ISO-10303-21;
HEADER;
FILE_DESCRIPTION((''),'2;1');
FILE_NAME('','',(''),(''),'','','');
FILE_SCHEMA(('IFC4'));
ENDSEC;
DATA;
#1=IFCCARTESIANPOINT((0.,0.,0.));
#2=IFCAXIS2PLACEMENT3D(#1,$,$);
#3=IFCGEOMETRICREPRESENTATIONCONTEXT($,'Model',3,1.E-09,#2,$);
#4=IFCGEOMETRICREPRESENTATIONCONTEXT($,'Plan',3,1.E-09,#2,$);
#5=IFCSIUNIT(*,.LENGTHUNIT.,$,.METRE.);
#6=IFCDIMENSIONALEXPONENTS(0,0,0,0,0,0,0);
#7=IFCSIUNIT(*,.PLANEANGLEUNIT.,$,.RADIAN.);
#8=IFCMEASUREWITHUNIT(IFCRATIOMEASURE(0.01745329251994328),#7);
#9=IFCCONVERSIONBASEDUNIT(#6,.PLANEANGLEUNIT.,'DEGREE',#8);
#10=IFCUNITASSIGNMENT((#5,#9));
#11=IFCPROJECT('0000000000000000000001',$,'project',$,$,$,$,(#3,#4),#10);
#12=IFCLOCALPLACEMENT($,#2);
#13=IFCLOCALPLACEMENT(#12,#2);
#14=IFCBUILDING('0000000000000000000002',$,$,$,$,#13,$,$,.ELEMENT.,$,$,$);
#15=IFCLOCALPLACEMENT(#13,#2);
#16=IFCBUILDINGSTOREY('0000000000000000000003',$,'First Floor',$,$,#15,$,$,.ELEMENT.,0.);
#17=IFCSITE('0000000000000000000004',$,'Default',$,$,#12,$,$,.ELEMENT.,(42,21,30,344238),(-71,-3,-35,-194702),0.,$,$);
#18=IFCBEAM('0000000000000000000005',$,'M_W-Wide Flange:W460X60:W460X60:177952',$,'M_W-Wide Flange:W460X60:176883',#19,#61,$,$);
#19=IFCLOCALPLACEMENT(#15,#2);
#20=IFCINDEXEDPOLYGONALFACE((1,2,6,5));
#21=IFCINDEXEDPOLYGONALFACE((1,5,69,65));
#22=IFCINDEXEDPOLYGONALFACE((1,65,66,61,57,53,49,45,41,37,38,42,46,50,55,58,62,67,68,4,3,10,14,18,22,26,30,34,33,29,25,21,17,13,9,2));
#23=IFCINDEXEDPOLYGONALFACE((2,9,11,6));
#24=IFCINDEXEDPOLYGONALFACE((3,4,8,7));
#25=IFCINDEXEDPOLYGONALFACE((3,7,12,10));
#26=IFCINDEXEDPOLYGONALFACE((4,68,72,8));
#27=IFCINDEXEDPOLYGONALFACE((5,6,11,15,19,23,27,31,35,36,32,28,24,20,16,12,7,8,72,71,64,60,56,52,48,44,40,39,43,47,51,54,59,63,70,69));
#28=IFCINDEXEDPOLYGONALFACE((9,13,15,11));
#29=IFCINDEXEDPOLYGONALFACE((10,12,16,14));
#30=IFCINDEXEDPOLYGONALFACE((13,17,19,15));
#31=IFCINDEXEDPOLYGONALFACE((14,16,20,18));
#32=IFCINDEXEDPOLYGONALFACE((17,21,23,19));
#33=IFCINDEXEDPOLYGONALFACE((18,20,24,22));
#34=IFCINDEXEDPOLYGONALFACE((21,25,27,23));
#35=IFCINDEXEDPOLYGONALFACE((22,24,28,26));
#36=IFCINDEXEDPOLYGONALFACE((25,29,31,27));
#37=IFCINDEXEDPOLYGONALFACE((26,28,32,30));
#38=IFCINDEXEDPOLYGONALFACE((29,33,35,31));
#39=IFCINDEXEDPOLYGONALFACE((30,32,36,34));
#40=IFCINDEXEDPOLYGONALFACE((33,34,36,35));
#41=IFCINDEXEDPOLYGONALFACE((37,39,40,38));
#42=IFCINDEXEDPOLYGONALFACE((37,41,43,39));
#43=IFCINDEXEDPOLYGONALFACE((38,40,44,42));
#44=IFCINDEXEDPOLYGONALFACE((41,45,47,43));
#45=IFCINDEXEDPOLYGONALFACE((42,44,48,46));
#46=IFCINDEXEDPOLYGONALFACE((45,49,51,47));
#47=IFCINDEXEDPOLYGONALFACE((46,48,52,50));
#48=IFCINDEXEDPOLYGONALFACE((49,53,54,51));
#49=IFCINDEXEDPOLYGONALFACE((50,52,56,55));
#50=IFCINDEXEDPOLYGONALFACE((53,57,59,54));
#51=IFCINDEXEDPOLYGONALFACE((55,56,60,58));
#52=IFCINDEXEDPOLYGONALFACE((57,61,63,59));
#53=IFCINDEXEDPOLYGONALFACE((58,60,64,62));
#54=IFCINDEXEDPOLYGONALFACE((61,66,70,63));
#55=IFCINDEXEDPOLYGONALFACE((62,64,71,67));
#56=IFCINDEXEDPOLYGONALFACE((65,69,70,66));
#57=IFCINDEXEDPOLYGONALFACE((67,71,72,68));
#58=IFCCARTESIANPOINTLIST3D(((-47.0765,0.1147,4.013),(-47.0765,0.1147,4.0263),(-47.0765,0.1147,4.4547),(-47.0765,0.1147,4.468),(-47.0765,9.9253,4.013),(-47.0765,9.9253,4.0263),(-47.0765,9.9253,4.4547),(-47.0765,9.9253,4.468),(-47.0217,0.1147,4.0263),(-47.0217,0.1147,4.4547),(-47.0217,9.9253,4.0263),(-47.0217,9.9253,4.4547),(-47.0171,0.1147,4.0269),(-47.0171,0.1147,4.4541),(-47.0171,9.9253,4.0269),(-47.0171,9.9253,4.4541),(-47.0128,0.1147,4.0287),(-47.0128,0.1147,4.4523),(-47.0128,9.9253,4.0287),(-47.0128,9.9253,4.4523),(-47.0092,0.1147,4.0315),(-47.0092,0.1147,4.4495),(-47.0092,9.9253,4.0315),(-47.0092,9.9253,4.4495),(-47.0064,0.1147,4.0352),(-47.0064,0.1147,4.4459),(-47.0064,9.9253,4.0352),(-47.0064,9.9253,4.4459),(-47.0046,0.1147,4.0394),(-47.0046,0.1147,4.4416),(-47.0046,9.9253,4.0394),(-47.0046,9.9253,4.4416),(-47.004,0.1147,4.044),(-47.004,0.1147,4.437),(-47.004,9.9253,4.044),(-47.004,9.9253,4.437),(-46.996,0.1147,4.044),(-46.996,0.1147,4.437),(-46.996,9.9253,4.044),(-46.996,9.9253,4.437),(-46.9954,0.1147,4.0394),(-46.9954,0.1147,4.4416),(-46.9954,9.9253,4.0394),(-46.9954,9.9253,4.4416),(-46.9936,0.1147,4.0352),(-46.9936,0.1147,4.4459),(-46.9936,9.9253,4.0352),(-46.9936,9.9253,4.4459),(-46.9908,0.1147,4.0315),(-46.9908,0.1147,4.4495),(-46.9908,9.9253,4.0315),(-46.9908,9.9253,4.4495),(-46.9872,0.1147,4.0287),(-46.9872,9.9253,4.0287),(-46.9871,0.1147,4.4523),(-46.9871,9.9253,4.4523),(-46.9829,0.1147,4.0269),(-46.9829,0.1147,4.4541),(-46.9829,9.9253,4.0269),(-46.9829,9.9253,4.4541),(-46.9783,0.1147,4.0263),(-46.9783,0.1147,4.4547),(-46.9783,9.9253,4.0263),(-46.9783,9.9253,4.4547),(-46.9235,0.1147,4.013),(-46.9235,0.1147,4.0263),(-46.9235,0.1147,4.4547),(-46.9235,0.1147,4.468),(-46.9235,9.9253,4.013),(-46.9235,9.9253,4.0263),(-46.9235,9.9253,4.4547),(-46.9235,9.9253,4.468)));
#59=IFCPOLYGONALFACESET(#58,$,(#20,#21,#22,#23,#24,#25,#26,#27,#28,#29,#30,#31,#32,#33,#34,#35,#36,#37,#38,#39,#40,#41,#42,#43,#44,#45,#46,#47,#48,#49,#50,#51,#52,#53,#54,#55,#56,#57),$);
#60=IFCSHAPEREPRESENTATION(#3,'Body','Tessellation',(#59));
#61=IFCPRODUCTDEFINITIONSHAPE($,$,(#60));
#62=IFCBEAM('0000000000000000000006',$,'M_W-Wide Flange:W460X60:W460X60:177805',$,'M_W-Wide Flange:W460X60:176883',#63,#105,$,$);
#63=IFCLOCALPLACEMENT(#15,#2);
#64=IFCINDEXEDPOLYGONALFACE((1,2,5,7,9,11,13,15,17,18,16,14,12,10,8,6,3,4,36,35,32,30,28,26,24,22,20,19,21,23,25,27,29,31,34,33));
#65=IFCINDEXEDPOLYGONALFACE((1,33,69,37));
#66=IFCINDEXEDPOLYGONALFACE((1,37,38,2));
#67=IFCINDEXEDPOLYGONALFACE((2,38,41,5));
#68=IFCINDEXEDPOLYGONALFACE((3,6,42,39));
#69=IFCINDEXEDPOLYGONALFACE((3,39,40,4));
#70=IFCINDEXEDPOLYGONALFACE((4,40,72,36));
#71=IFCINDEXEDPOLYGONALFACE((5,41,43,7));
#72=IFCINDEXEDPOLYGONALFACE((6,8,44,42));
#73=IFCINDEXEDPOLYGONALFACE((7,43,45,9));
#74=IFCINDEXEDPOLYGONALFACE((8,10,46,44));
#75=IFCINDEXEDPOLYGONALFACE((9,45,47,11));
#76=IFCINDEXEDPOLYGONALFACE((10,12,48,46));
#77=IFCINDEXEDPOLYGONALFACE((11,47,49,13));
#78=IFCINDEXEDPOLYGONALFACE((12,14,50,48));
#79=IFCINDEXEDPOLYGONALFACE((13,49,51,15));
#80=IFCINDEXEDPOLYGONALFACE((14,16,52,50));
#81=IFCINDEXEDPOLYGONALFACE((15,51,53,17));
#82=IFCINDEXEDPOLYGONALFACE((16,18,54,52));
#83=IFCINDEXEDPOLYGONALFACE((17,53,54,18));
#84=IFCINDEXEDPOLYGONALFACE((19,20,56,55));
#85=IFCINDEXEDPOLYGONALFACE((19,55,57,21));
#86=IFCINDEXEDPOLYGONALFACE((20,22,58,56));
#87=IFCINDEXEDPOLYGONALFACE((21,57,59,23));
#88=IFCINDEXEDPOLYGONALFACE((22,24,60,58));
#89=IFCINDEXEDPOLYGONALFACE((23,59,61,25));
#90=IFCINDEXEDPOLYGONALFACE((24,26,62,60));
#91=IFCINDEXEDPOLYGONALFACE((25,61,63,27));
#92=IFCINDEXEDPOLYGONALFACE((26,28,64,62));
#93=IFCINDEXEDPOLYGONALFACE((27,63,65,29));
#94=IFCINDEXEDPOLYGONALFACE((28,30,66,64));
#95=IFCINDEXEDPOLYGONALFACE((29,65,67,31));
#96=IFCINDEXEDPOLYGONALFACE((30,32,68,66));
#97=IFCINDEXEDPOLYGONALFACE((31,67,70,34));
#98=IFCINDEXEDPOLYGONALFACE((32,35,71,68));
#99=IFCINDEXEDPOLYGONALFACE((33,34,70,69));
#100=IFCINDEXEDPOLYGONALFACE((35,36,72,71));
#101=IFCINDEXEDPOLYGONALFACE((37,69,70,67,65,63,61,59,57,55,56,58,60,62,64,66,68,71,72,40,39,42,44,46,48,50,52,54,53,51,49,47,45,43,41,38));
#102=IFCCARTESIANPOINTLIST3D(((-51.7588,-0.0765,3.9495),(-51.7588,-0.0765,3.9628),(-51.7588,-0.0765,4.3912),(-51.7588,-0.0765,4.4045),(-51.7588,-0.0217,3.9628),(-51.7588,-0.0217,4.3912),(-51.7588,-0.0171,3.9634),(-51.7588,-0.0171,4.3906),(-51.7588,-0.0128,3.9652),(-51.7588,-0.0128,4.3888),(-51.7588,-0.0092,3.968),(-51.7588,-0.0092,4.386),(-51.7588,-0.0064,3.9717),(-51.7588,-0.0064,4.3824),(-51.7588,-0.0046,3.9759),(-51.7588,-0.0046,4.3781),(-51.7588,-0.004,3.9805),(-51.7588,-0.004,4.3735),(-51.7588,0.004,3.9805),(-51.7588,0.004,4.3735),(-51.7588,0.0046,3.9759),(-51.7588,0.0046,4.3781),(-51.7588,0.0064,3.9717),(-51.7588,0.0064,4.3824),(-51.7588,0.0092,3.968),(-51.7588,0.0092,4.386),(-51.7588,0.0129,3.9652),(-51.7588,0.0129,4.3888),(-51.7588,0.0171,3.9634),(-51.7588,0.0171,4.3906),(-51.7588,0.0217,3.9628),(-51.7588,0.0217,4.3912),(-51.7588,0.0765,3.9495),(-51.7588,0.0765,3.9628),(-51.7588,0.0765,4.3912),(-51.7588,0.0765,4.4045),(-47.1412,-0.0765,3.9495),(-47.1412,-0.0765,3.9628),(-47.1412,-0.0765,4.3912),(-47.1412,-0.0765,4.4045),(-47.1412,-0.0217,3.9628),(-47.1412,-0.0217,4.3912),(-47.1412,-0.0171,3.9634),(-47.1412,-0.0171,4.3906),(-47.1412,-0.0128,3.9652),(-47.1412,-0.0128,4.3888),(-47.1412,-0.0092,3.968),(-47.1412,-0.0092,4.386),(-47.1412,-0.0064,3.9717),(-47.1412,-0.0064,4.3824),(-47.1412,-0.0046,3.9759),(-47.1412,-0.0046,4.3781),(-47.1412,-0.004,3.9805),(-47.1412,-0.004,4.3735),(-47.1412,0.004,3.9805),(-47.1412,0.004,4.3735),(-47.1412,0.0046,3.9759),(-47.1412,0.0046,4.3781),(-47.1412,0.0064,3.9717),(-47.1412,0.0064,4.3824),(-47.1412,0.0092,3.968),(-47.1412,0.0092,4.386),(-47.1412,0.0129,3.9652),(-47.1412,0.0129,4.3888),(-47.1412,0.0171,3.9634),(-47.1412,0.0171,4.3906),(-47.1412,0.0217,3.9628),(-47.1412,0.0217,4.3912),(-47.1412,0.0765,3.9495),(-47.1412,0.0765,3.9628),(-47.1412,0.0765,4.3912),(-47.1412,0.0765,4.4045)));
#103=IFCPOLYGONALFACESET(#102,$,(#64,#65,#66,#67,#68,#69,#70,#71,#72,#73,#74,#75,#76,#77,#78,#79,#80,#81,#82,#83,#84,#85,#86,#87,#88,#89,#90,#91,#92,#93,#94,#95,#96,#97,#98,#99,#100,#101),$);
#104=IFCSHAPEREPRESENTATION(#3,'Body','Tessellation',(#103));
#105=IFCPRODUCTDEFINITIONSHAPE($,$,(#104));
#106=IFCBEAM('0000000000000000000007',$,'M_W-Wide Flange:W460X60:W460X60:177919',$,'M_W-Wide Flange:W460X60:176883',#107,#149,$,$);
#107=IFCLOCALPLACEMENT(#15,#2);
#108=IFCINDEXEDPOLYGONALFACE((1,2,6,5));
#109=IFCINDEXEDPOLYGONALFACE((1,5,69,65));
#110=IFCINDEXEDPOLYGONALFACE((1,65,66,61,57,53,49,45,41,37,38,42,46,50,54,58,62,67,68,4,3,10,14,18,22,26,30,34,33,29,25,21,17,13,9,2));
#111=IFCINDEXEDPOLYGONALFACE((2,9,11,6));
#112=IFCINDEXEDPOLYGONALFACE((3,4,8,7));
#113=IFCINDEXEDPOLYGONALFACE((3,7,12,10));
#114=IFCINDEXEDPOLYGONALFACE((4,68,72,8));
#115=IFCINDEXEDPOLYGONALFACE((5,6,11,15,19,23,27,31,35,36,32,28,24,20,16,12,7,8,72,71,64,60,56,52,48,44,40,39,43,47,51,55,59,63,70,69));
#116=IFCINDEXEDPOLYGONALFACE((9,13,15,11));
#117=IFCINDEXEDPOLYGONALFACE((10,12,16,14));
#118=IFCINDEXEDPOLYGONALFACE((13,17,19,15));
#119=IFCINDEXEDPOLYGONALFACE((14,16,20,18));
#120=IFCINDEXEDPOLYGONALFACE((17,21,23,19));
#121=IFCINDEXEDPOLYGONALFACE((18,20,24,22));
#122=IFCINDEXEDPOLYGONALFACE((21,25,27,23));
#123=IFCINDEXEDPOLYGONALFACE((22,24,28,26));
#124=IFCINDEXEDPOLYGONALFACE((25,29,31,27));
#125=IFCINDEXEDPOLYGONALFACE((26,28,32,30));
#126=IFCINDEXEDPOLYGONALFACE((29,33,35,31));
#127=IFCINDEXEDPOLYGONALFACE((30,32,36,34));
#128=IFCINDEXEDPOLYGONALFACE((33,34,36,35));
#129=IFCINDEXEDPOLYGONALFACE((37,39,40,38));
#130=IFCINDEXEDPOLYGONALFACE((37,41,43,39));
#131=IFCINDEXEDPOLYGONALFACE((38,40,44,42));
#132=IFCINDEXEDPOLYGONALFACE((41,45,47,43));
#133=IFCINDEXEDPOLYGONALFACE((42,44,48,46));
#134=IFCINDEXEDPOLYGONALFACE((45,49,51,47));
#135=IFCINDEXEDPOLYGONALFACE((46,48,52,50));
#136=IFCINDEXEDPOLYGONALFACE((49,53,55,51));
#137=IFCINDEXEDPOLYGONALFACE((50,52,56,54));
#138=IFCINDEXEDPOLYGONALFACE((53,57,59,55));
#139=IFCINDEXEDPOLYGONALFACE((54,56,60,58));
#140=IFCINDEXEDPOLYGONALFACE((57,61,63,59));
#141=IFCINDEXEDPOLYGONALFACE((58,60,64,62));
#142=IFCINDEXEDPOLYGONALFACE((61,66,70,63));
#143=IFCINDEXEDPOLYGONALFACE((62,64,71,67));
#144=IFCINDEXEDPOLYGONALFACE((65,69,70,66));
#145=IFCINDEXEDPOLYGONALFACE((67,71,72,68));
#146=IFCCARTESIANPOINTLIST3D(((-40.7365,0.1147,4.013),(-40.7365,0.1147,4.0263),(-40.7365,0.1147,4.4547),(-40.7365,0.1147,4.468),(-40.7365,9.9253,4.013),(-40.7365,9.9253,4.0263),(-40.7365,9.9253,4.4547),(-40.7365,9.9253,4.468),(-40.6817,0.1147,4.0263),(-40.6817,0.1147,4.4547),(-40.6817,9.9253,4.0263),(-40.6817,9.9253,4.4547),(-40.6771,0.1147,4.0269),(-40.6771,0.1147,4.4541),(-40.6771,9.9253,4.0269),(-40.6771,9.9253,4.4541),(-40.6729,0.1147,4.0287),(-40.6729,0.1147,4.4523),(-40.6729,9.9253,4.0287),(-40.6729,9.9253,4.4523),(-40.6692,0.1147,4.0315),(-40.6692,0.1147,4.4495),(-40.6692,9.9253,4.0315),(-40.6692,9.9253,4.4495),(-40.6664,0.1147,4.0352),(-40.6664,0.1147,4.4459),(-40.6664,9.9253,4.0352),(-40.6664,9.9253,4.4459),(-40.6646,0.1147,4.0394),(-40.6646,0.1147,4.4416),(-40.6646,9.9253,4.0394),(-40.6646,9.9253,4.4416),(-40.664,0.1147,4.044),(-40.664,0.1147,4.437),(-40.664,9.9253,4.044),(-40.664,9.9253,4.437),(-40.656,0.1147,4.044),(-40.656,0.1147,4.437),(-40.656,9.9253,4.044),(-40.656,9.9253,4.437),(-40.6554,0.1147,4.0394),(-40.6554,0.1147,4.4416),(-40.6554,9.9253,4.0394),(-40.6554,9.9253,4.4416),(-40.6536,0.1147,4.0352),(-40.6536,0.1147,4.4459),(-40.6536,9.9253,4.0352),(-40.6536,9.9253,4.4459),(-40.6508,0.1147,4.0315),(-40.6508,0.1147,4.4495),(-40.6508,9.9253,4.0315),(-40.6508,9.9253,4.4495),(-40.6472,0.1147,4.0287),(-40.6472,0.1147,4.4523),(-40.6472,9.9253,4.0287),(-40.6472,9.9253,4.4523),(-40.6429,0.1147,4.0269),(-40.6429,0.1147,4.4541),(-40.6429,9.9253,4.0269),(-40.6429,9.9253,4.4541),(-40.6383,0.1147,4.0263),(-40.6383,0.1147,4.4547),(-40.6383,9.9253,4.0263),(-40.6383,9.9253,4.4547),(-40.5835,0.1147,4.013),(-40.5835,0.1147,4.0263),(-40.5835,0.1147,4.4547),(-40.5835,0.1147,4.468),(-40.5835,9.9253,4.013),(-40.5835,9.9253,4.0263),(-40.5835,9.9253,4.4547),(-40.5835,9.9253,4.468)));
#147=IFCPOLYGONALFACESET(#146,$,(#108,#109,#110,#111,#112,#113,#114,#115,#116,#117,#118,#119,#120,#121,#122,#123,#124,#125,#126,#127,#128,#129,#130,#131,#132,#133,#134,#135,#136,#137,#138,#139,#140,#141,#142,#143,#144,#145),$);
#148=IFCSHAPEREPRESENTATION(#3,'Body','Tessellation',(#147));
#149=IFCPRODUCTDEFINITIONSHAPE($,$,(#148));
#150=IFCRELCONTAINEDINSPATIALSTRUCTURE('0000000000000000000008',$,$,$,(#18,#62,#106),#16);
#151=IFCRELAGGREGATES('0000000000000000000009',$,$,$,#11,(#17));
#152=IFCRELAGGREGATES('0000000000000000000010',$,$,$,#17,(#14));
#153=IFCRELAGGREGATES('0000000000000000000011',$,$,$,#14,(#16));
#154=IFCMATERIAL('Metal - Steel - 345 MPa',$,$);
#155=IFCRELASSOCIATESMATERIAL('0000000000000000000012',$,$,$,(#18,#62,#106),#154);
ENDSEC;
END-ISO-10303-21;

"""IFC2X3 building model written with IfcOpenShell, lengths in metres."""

from ifc_helpers import new_model, entity, si_unit, converted_unit, frame, frame_2d, origin, place, context, project, spatial, polyline, circle_curve, parameter, trimmed, segment, composite_curve, outline, extrude, material, element, save


model = new_model("IFC2X3")

# Units and contexts
model_context = context("Model", 3, precision=1e-09, world=origin())
plan_context = context("Plan", 3, precision=1e-09, world=origin())
ifc_project = project(units=[si_unit("LENGTHUNIT", "METRE"), converted_unit("PLANEANGLEUNIT", "DEGREE", entity("IfcRatioMeasure", 0.01745329251994328), si_unit("PLANEANGLEUNIT", "RADIAN"), dimensions=[0, 0, 0, 0, 0, 0, 0])], contexts=[model_context, plan_context])

# Site, building, storey
site_placement = place(None, origin())
site = spatial("IfcSite", under=ifc_project, at=site_placement, Name="Default", CompositionType="ELEMENT", RefLatitude=(42, 21, 30, 344238), RefLongitude=(-71, -3, -35, -194702), RefElevation=0.0)
building_placement = place(site_placement, origin())
building = spatial("IfcBuilding", under=site, at=building_placement, CompositionType="ELEMENT")
storey_placement = place(building_placement, origin())
storey = spatial("IfcBuildingStorey", under=building, at=storey_placement, Name="First Floor", CompositionType="ELEMENT", Elevation=0.0)

# Beams
ifc_material_1 = material(Name="Metal - Steel - 345 MPa")
beam_1_placement = place(storey_placement, frame((-47.0, -0.0014, 4.468)))
element("IfcBeam", 1, at=beam_1_placement, inside=storey, material=ifc_material_1, Name="M_W-Wide Flange:W460X60:W460X60:177952", ObjectType="M_W-Wide Flange:W460X60:176883", context=model_context, shape_type="SweptSolid", body=[
    extrude(outline(composite_curve([segment(polyline([(-0.0765, -0.2142), (-0.0765, -0.2275)]), True, "CONTINUOUS"), segment(polyline([(-0.0765, -0.2275), (0.0765, -0.2275)]), True, "CONTINUOUS"), segment(polyline([(0.0765, -0.2275), (0.0765, -0.2142)]), True, "CONTINUOUS"), segment(polyline([(0.0765, -0.2142), (0.0217, -0.2142)]), True, "CONTINUOUS"), segment(trimmed(circle_curve(frame_2d((0.0217, -0.1965), x_axis=(0.0, -1.0)), 0.0177), [parameter(270.0)], [parameter(360.0)], True, "PARAMETER"), False, "CONTINUOUS"), segment(polyline([(0.004, -0.1965), (0.004, 0.1965)]), True, "CONTINUOUS"), segment(trimmed(circle_curve(frame_2d((0.0217, 0.1965), x_axis=(-1.0, 0.0)), 0.0177), [parameter(270.0)], [parameter(360.0)], True, "PARAMETER"), False, "CONTINUOUS"), segment(polyline([(0.0217, 0.2142), (0.0765, 0.2142)]), True, "CONTINUOUS"), segment(polyline([(0.0765, 0.2142), (0.0765, 0.2275)]), True, "CONTINUOUS"), segment(polyline([(0.0765, 0.2275), (-0.0765, 0.2275)]), True, "CONTINUOUS"), segment(polyline([(-0.0765, 0.2275), (-0.0765, 0.2142)]), True, "CONTINUOUS"), segment(polyline([(-0.0765, 0.2142), (-0.0217, 0.2142)]), True, "CONTINUOUS"), segment(trimmed(circle_curve(frame_2d((-0.0217, 0.1965), x_axis=(0.0, 1.0)), 0.0177), [parameter(270.0)], [parameter(360.0)], True, "PARAMETER"), False, "CONTINUOUS"), segment(polyline([(-0.004, 0.1965), (-0.004, -0.1965)]), True, "CONTINUOUS"), segment(trimmed(circle_curve(frame_2d((-0.0217, -0.1965), x_axis=(1.0, 0.0)), 0.0177), [parameter(270.0)], [parameter(0.0)], True, "PARAMETER"), False, "CONTINUOUS"), segment(polyline([(-0.0217, -0.2142), (-0.0765, -0.2142)]), True, "CONTINUOUS")], self_intersect=False)), frame((0.0, 0.1161, -0.2275), z_axis=(0.0, -1.0, 0.0), x_axis=(1.0, 0.0, 0.0)), (0.0, 0.0, -1.0), 9.8106),
])
beam_2_placement = place(storey_placement, frame((-51.9028, 0.0, 4.4045), z_axis=(0.0, 0.0, 1.0), x_axis=(0.0, -1.0, 0.0)))
element("IfcBeam", 2, at=beam_2_placement, inside=storey, material=ifc_material_1, Name="M_W-Wide Flange:W460X60:W460X60:177805", ObjectType="M_W-Wide Flange:W460X60:176883", context=model_context, shape_type="SweptSolid", body=[
    extrude(outline(composite_curve([segment(polyline([(-0.0765, -0.2142), (-0.0765, -0.2275)]), True, "CONTINUOUS"), segment(polyline([(-0.0765, -0.2275), (0.0765, -0.2275)]), True, "CONTINUOUS"), segment(polyline([(0.0765, -0.2275), (0.0765, -0.2142)]), True, "CONTINUOUS"), segment(polyline([(0.0765, -0.2142), (0.0217, -0.2142)]), True, "CONTINUOUS"), segment(trimmed(circle_curve(frame_2d((0.0217, -0.1965), x_axis=(1.0, 0.0)), 0.0177), [parameter(180.0)], [parameter(270.0)], True, "PARAMETER"), False, "CONTINUOUS"), segment(polyline([(0.004, -0.1965), (0.004, 0.1965)]), True, "CONTINUOUS"), segment(trimmed(circle_curve(frame_2d((0.0217, 0.1965), x_axis=(1.0, 0.0)), 0.0177), [parameter(90.0)], [parameter(180.0)], True, "PARAMETER"), False, "CONTINUOUS"), segment(polyline([(0.0217, 0.2142), (0.0765, 0.2142)]), True, "CONTINUOUS"), segment(polyline([(0.0765, 0.2142), (0.0765, 0.2275)]), True, "CONTINUOUS"), segment(polyline([(0.0765, 0.2275), (-0.0765, 0.2275)]), True, "CONTINUOUS"), segment(polyline([(-0.0765, 0.2275), (-0.0765, 0.2142)]), True, "CONTINUOUS"), segment(polyline([(-0.0765, 0.2142), (-0.0217, 0.2142)]), True, "CONTINUOUS"), segment(trimmed(circle_curve(frame_2d((-0.0217, 0.1965), x_axis=(1.0, 0.0)), 0.0177), [parameter(360.0)], [parameter(90.0)], True, "PARAMETER"), False, "CONTINUOUS"), segment(polyline([(-0.004, 0.1965), (-0.004, -0.1965)]), True, "CONTINUOUS"), segment(trimmed(circle_curve(frame_2d((-0.0217, -0.1965), x_axis=(1.0, 0.0)), 0.0177), [parameter(270.0)], [parameter(0.0)], True, "PARAMETER"), False, "CONTINUOUS"), segment(polyline([(-0.0217, -0.2142), (-0.0765, -0.2142)]), True, "CONTINUOUS")], self_intersect=False)), frame((0.0, 0.144, -0.2275), z_axis=(0.0, -1.0, 0.0), x_axis=(1.0, 0.0, 0.0)), (0.0, 0.0, -1.0), 4.6176),
])
beam_3_placement = place(storey_placement, frame((-40.66, 10.0414, 4.468), z_axis=(0.0, 0.0, 1.0), x_axis=(-1.0, 0.0, 0.0)))
element("IfcBeam", 3, at=beam_3_placement, inside=storey, material=ifc_material_1, Name="M_W-Wide Flange:W460X60:W460X60:177919", ObjectType="M_W-Wide Flange:W460X60:176883", context=model_context, shape_type="SweptSolid", body=[
    extrude(outline(composite_curve([segment(polyline([(0.2142, -0.0765), (0.2275, -0.0765)]), True, "CONTINUOUS"), segment(polyline([(0.2275, -0.0765), (0.2275, 0.0765)]), True, "CONTINUOUS"), segment(polyline([(0.2275, 0.0765), (0.2142, 0.0765)]), True, "CONTINUOUS"), segment(polyline([(0.2142, 0.0765), (0.2142, 0.0217)]), True, "CONTINUOUS"), segment(trimmed(circle_curve(frame_2d((0.1965, 0.0217), x_axis=(1.0, 0.0)), 0.0177), [parameter(270.0)], [parameter(360.0)], True, "PARAMETER"), False, "CONTINUOUS"), segment(polyline([(0.1965, 0.004), (-0.1965, 0.004)]), True, "CONTINUOUS"), segment(trimmed(circle_curve(frame_2d((-0.1965, 0.0217), x_axis=(0.0, -1.0)), 0.0177), [parameter(270.0)], [parameter(360.0)], True, "PARAMETER"), False, "CONTINUOUS"), segment(polyline([(-0.2142, 0.0217), (-0.2142, 0.0765)]), True, "CONTINUOUS"), segment(polyline([(-0.2142, 0.0765), (-0.2275, 0.0765)]), True, "CONTINUOUS"), segment(polyline([(-0.2275, 0.0765), (-0.2275, -0.0765)]), True, "CONTINUOUS"), segment(polyline([(-0.2275, -0.0765), (-0.2142, -0.0765)]), True, "CONTINUOUS"), segment(polyline([(-0.2142, -0.0765), (-0.2142, -0.0217)]), True, "CONTINUOUS"), segment(trimmed(circle_curve(frame_2d((-0.1965, -0.0217), x_axis=(-1.0, 0.0)), 0.0177), [parameter(270.0)], [parameter(360.0)], True, "PARAMETER"), False, "CONTINUOUS"), segment(polyline([(-0.1965, -0.004), (0.1965, -0.004)]), True, "CONTINUOUS"), segment(trimmed(circle_curve(frame_2d((0.1965, -0.0217), x_axis=(0.0, 1.0)), 0.0177), [parameter(270.0)], [parameter(0.0)], True, "PARAMETER"), False, "CONTINUOUS"), segment(polyline([(0.2142, -0.0217), (0.2142, -0.0765)]), True, "CONTINUOUS")], self_intersect=False)), frame((0.0, 9.9267, -0.2275), z_axis=(0.0, -1.0, 0.0), x_axis=(0.0, 0.0, -1.0)), (0.0, 0.0, 1.0), 9.8106),
])

save(model, "model.ifc")
